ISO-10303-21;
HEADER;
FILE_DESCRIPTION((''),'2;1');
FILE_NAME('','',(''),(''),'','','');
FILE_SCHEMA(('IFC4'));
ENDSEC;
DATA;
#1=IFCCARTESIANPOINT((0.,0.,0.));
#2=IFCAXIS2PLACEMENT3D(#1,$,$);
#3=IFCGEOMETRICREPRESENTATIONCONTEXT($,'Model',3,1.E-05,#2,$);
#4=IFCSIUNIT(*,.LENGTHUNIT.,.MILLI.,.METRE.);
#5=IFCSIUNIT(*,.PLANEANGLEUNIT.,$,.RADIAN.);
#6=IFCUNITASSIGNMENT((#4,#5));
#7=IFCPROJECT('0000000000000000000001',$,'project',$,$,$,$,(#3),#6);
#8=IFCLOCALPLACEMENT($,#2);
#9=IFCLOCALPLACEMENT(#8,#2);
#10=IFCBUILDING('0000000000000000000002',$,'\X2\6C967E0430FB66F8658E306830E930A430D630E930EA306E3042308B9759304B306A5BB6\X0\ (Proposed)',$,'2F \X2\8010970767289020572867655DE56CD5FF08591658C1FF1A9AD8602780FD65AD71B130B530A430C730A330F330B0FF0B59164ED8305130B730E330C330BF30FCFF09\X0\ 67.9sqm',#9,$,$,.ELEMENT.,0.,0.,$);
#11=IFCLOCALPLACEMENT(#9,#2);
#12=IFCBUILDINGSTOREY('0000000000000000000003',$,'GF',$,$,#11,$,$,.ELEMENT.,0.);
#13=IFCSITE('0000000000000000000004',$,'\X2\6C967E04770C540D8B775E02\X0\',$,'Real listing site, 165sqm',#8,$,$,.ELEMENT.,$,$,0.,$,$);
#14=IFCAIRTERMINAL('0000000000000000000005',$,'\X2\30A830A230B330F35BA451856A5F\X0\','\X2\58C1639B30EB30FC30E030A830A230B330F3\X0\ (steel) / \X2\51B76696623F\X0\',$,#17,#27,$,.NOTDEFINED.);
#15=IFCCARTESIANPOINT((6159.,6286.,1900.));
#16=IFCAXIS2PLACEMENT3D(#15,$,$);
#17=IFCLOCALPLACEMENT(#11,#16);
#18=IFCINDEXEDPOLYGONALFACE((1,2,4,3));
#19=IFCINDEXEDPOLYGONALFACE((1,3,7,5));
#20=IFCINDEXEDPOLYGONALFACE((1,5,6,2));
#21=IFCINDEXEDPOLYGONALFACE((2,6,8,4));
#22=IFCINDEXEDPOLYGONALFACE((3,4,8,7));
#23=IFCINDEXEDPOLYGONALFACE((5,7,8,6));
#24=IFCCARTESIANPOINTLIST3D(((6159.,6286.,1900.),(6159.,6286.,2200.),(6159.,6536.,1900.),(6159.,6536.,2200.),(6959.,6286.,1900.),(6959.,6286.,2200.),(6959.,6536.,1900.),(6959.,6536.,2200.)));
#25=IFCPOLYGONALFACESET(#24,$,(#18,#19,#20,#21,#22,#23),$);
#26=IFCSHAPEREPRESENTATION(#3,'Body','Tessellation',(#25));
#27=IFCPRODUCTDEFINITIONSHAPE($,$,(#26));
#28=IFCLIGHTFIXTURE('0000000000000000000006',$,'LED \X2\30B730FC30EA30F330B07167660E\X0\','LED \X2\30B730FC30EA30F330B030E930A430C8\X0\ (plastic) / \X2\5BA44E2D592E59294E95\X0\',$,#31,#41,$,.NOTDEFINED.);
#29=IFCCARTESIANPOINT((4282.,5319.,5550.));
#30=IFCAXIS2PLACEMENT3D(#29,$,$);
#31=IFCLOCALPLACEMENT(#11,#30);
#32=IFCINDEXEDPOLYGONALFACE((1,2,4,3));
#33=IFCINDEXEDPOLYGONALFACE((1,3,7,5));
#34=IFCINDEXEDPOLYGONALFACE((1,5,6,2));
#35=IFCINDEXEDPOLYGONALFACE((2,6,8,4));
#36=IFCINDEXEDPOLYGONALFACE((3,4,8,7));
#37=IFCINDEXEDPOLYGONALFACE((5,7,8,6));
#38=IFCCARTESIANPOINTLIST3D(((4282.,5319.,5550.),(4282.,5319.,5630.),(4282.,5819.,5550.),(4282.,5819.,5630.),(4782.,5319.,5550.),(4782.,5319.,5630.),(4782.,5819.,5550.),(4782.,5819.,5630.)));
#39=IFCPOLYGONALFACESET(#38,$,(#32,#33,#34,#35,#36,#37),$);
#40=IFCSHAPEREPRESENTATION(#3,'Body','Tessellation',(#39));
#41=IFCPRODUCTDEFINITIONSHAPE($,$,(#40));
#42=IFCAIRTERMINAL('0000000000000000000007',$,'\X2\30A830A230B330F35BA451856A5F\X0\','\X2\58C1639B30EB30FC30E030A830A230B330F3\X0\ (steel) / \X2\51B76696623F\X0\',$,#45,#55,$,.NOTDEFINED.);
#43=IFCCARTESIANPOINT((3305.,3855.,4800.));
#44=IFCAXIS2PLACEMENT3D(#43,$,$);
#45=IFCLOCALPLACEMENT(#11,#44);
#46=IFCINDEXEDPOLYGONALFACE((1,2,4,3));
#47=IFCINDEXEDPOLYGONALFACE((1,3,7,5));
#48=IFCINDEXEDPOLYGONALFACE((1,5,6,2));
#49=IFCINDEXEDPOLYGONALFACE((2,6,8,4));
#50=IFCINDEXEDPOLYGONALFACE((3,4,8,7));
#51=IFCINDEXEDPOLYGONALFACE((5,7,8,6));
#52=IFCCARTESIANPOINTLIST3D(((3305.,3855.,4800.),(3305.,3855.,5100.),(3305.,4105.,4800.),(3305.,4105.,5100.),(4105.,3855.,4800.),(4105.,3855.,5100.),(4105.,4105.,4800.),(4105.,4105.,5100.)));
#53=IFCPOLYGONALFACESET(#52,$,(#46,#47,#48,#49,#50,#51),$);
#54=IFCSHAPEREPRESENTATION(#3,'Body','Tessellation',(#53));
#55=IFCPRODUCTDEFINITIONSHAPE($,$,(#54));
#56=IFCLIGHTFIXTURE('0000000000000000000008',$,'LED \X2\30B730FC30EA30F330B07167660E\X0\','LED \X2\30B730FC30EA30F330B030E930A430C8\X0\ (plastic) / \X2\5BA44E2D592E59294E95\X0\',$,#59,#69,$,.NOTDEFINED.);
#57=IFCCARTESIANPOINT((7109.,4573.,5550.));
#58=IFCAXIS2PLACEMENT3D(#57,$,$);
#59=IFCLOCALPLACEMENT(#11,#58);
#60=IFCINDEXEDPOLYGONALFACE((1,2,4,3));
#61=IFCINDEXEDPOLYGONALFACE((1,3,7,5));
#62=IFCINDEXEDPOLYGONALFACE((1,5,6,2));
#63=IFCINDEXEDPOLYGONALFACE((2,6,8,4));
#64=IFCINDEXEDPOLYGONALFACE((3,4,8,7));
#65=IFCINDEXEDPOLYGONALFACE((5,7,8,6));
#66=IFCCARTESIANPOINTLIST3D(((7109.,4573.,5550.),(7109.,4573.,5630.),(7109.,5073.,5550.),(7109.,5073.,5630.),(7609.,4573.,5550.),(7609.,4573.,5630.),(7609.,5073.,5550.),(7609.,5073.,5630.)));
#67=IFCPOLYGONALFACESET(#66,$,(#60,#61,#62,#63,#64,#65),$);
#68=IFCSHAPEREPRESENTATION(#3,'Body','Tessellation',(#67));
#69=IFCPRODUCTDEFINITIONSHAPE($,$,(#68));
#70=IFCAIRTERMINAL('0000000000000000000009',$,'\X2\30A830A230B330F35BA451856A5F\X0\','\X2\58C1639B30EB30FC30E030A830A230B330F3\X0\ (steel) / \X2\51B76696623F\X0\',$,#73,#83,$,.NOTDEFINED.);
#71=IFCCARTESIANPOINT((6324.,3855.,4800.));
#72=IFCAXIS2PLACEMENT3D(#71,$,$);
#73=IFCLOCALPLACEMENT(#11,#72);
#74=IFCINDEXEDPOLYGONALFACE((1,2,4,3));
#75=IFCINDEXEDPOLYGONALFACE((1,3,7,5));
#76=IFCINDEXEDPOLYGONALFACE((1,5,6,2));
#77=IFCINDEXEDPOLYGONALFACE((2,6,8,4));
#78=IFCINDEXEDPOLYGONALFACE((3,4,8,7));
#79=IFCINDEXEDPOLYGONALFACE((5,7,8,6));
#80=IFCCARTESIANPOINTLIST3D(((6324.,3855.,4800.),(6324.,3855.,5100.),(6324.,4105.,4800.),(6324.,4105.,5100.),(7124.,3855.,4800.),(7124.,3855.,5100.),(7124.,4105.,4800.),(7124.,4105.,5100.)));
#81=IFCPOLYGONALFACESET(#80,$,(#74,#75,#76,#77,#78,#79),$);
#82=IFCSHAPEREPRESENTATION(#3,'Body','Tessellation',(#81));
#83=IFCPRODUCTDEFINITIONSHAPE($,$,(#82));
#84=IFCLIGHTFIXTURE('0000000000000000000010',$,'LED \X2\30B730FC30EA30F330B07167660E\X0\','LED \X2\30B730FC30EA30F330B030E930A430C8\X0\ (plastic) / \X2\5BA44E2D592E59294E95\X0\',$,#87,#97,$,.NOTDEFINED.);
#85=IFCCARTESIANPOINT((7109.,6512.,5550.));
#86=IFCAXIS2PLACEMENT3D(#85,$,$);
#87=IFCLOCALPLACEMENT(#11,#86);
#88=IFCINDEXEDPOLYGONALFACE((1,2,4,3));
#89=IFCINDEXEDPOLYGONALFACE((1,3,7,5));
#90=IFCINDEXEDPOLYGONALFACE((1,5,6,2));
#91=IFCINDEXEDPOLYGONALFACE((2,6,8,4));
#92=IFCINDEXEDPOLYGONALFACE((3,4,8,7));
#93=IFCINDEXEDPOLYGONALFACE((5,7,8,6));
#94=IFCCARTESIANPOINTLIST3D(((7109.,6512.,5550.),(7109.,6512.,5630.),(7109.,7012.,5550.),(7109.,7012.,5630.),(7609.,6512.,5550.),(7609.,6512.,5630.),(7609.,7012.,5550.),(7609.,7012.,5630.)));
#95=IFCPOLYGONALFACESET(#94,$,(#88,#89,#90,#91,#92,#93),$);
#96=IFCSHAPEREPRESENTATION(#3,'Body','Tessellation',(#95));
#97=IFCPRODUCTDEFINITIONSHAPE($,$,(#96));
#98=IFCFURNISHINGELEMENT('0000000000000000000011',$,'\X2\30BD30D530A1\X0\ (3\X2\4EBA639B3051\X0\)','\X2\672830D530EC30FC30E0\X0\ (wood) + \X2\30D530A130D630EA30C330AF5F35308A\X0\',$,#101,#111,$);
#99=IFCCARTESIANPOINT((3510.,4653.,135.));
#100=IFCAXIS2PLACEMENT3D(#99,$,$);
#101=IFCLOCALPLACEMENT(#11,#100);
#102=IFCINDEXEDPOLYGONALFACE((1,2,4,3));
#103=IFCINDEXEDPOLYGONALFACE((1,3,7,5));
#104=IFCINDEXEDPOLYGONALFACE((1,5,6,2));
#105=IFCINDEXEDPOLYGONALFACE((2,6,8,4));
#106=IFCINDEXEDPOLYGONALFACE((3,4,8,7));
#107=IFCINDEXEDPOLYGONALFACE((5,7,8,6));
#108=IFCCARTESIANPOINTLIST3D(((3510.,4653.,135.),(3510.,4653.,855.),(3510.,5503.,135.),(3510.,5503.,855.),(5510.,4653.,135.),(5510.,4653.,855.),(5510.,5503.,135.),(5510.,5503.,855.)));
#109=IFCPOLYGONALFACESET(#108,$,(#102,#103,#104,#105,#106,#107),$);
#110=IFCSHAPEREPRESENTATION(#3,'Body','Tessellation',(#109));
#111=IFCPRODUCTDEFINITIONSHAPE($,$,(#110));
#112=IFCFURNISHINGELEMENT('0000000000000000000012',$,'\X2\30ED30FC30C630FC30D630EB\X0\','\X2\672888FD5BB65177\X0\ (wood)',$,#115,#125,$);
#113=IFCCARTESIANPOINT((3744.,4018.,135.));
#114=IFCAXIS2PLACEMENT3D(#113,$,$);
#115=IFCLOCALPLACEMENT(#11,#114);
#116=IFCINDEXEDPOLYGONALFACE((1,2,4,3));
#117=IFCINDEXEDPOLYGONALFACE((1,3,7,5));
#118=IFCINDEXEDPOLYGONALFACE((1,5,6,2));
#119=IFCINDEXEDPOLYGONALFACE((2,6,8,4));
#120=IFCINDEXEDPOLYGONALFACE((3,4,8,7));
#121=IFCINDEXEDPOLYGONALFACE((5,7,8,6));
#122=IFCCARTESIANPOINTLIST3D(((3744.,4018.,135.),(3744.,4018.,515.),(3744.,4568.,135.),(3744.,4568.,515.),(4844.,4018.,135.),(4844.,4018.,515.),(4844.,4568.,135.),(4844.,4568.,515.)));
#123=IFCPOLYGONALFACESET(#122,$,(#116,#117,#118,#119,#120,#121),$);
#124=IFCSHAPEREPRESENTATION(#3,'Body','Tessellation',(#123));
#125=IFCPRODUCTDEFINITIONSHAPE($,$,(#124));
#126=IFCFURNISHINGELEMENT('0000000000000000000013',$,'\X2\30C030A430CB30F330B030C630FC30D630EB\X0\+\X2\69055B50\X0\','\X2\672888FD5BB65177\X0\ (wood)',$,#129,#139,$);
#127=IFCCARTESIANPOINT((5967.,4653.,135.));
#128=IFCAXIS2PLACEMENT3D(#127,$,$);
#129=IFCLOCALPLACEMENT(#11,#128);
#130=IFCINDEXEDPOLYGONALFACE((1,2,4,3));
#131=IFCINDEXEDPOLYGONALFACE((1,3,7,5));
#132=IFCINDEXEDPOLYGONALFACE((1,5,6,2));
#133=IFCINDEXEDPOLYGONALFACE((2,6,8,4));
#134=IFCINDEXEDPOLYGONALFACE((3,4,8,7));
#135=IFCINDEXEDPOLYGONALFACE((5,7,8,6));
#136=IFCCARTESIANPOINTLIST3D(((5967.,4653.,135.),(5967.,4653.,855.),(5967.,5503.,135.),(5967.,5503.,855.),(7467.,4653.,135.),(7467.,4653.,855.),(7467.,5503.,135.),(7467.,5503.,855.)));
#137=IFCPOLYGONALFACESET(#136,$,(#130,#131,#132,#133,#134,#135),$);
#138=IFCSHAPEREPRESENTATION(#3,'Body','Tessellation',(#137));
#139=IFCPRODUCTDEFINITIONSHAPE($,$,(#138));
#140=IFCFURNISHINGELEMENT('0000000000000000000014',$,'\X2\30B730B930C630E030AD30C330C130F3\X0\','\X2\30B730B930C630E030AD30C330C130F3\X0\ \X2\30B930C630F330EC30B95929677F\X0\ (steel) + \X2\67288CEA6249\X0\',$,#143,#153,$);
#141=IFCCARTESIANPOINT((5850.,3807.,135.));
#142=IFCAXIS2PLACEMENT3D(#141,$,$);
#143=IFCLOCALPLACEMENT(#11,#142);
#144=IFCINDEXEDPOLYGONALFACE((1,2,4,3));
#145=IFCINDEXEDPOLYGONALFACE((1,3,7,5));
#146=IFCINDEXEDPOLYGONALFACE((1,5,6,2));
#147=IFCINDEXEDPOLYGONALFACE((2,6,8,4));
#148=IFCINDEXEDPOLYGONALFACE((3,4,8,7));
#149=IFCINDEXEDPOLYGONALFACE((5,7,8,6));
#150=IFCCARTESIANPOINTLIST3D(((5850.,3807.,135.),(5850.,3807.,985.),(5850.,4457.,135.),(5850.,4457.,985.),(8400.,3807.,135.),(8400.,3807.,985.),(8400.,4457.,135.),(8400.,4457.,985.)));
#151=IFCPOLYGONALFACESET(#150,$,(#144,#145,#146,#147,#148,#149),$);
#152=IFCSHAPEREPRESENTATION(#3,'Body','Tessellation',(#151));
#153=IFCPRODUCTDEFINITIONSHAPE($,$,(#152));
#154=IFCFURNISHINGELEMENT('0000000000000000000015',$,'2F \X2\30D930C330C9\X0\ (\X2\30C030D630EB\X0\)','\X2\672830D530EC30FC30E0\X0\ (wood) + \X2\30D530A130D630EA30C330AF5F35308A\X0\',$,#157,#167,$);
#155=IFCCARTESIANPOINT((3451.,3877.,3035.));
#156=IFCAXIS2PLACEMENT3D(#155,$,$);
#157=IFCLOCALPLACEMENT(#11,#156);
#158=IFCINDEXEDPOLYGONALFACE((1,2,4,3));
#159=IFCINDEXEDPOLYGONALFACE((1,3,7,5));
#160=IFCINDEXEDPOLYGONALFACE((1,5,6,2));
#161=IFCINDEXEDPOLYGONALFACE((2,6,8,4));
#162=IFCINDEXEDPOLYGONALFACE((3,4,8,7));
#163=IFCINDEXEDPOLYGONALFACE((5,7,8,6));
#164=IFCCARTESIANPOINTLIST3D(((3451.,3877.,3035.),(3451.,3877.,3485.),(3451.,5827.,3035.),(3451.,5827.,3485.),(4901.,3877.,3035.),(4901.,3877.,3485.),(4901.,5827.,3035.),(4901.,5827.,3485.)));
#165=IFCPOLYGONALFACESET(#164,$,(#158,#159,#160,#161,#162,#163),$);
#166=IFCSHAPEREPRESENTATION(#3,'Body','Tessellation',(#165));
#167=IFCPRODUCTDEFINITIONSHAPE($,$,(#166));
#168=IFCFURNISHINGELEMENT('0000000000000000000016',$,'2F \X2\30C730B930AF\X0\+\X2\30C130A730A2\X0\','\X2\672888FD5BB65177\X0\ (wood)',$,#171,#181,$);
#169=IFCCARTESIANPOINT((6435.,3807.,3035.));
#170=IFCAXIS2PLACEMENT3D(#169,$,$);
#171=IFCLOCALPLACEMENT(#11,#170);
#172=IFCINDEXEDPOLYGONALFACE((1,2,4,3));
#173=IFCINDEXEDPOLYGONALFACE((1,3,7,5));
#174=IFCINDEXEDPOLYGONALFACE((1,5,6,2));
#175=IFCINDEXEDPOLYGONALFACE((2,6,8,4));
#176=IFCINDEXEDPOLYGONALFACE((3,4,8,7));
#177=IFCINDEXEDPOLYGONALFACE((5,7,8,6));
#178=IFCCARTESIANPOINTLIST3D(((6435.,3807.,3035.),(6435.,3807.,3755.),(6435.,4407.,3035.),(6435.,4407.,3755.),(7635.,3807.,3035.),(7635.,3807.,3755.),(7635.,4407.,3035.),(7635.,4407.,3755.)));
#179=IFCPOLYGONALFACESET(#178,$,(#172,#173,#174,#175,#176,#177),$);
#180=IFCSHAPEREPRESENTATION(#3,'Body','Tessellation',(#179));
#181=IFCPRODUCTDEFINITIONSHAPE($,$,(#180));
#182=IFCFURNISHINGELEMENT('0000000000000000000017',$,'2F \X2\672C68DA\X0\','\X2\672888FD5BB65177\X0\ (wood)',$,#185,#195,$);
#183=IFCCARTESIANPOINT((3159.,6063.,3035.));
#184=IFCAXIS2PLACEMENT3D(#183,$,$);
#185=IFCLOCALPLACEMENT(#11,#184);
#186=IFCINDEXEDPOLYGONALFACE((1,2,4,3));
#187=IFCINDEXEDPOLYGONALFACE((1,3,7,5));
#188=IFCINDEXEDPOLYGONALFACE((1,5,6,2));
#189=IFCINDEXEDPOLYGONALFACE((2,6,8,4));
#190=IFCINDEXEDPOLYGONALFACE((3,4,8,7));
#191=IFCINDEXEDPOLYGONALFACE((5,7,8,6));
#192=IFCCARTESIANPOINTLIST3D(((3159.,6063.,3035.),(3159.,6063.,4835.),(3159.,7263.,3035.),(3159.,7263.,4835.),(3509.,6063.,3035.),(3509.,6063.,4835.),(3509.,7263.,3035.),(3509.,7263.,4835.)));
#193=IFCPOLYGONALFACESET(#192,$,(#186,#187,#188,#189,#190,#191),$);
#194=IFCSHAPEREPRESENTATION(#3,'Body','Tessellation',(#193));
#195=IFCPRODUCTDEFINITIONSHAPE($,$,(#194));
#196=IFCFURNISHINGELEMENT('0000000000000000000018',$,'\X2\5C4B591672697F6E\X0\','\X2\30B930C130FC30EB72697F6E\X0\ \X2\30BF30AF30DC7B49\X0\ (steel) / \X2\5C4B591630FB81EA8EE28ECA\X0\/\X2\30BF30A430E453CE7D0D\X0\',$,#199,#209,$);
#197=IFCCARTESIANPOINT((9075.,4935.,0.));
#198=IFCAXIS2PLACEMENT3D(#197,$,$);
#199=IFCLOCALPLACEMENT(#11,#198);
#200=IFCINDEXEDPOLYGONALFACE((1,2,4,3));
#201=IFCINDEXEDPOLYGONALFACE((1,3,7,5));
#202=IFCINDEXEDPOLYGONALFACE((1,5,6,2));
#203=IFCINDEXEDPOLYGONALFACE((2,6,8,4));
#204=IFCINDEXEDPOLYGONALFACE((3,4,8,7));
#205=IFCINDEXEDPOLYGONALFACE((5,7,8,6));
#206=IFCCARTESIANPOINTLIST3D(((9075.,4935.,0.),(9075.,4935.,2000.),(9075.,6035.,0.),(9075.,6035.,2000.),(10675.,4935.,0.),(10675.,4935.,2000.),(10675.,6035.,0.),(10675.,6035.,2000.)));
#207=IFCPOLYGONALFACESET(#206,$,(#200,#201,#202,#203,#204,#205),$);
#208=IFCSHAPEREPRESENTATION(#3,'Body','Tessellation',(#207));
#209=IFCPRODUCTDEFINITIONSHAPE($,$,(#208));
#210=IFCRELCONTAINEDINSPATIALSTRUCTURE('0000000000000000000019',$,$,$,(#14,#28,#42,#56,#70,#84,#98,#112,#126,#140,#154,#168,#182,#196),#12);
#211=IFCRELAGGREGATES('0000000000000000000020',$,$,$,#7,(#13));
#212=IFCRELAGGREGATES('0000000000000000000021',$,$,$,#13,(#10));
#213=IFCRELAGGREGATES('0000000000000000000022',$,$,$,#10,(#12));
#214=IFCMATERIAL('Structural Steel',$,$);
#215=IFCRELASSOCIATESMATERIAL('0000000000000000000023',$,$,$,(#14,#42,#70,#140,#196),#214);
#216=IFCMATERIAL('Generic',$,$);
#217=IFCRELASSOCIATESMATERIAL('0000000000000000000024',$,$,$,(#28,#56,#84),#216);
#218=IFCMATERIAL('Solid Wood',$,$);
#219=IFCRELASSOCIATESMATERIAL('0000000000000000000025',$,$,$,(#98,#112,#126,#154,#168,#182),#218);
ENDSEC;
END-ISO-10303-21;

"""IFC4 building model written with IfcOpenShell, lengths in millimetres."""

from ifc_helpers import new_model, si_unit, frame, frame_2d, origin, place, context, project, spatial, rectangle, extrude, material, element, save


model = new_model("IFC4")

# Units and contexts
model_context = context("Model", 3, precision=1e-05, world=origin())
ifc_project = project(units=[si_unit("LENGTHUNIT", "METRE", prefix="MILLI"), si_unit("PLANEANGLEUNIT", "RADIAN")], contexts=[model_context])

# Site, building, storey
site_placement = place(None, origin())
site = spatial("IfcSite", under=ifc_project, at=site_placement, Name="沖縄県名護市", ObjectType="Real listing site, 165sqm", CompositionType="ELEMENT", RefElevation=0.0)
building_placement = place(site_placement, origin())
building = spatial("IfcBuilding", under=site, at=building_placement, Name="沖縄・書斎とライブラリのある静かな家 (Proposed)", ObjectType="2F 耐震木造在来工法（外壁：高性能断熱サイディング＋外付けシャッター） 67.9sqm", CompositionType="ELEMENT", ElevationOfRefHeight=0.0, ElevationOfTerrain=0.0)
storey_placement = place(building_placement, origin())
storey = spatial("IfcBuildingStorey", under=building, at=storey_placement, Name="GF", CompositionType="ELEMENT", Elevation=0.0)

# Shared definitions
ifc_material_1 = material(Name="Solid Wood")

# Shared definitions
ifc_material_2 = material(Name="Structural Steel")

# Shared definitions
ifc_material_3 = material(Name="Generic")

# Air terminal
air_terminal_1_placement = place(storey_placement, frame((6159.0, 6286.0, 1900.0)))
element("IfcAirTerminal", 1, at=air_terminal_1_placement, inside=storey, material=ifc_material_2, Name="エアコン室内機", Description="壁掛ルームエアコン (steel) / 冷暖房", PredefinedType="NOTDEFINED", context=model_context, shape_type="SweptSolid", body=[
    extrude(rectangle(XDim=800.0, YDim=250.0, at=frame_2d((400.0, 125.0))), frame((6159.0, 6286.0, 1900.0)), (0.0, 0.0, 1.0), 300.0),
])

# Light fixture
light_fixture_1_placement = place(storey_placement, frame((4282.0, 5319.0, 5550.0)))
element("IfcLightFixture", 2, at=light_fixture_1_placement, inside=storey, material=ifc_material_3, Name="LED シーリング照明", Description="LED シーリングライト (plastic) / 室中央天井", PredefinedType="NOTDEFINED", context=model_context, shape_type="SweptSolid", body=[
    extrude(rectangle(XDim=500.0, YDim=500.0, at=frame_2d((250.0, 250.0))), frame((4282.0, 5319.0, 5550.0)), (0.0, 0.0, 1.0), 80.0),
])

# Air terminal
air_terminal_2_placement = place(storey_placement, frame((3305.0, 3855.0, 4800.0)))
element("IfcAirTerminal", 3, at=air_terminal_2_placement, inside=storey, material=ifc_material_2, Name="エアコン室内機", Description="壁掛ルームエアコン (steel) / 冷暖房", PredefinedType="NOTDEFINED", context=model_context, shape_type="SweptSolid", body=[
    extrude(rectangle(XDim=800.0, YDim=250.0, at=frame_2d((400.0, 125.0))), frame((3305.0, 3855.0, 4800.0)), (0.0, 0.0, 1.0), 300.0),
])

# Light fixture
light_fixture_2_placement = place(storey_placement, frame((7109.0, 4573.0, 5550.0)))
element("IfcLightFixture", 4, at=light_fixture_2_placement, inside=storey, material=ifc_material_3, Name="LED シーリング照明", Description="LED シーリングライト (plastic) / 室中央天井", PredefinedType="NOTDEFINED", context=model_context, shape_type="SweptSolid", body=[
    extrude(rectangle(XDim=500.0, YDim=500.0, at=frame_2d((250.0, 250.0))), frame((7109.0, 4573.0, 5550.0)), (0.0, 0.0, 1.0), 80.0),
])

# Air terminal
air_terminal_3_placement = place(storey_placement, frame((6324.0, 3855.0, 4800.0)))
element("IfcAirTerminal", 5, at=air_terminal_3_placement, inside=storey, material=ifc_material_2, Name="エアコン室内機", Description="壁掛ルームエアコン (steel) / 冷暖房", PredefinedType="NOTDEFINED", context=model_context, shape_type="SweptSolid", body=[
    extrude(rectangle(XDim=800.0, YDim=250.0, at=frame_2d((400.0, 125.0))), frame((6324.0, 3855.0, 4800.0)), (0.0, 0.0, 1.0), 300.0),
])

# Light fixture
light_fixture_3_placement = place(storey_placement, frame((7109.0, 6512.0, 5550.0)))
element("IfcLightFixture", 6, at=light_fixture_3_placement, inside=storey, material=ifc_material_3, Name="LED シーリング照明", Description="LED シーリングライト (plastic) / 室中央天井", PredefinedType="NOTDEFINED", context=model_context, shape_type="SweptSolid", body=[
    extrude(rectangle(XDim=500.0, YDim=500.0, at=frame_2d((250.0, 250.0))), frame((7109.0, 6512.0, 5550.0)), (0.0, 0.0, 1.0), 80.0),
])

# Furnishing elements
furnishing_1_placement = place(storey_placement, frame((3510.0, 4653.0, 135.0)))
element("IfcFurnishingElement", 7, at=furnishing_1_placement, inside=storey, material=ifc_material_1, Name="ソファ (3人掛け)", Description="木フレーム (wood) + ファブリック張り", context=model_context, shape_type="SweptSolid", body=[
    extrude(rectangle(XDim=2000.0, YDim=850.0, at=frame_2d((1000.0, 425.0))), frame((3510.0, 4653.0, 135.0)), (0.0, 0.0, 1.0), 720.0),
])
furnishing_2_placement = place(storey_placement, frame((3744.0, 4018.0, 135.0)))
element("IfcFurnishingElement", 8, at=furnishing_2_placement, inside=storey, material=ifc_material_1, Name="ローテーブル", Description="木製家具 (wood)", context=model_context, shape_type="SweptSolid", body=[
    extrude(rectangle(XDim=1100.0, YDim=550.0, at=frame_2d((550.0, 275.0))), frame((3744.0, 4018.0, 135.0)), (0.0, 0.0, 1.0), 380.0),
])
furnishing_3_placement = place(storey_placement, frame((5967.0, 4653.0, 135.0)))
element("IfcFurnishingElement", 9, at=furnishing_3_placement, inside=storey, material=ifc_material_1, Name="ダイニングテーブル+椅子", Description="木製家具 (wood)", context=model_context, shape_type="SweptSolid", body=[
    extrude(rectangle(XDim=1500.0, YDim=850.0, at=frame_2d((750.0, 425.0))), frame((5967.0, 4653.0, 135.0)), (0.0, 0.0, 1.0), 720.0),
])
furnishing_4_placement = place(storey_placement, frame((5850.0, 3807.0, 135.0)))
element("IfcFurnishingElement", 10, at=furnishing_4_placement, inside=storey, material=ifc_material_2, Name="システムキッチン", Description="システムキッチン ステンレス天板 (steel) + 木質扉", context=model_context, shape_type="SweptSolid", body=[
    extrude(rectangle(XDim=2550.0, YDim=650.0, at=frame_2d((1275.0, 325.0))), frame((5850.0, 3807.0, 135.0)), (0.0, 0.0, 1.0), 850.0),
])
furnishing_5_placement = place(storey_placement, frame((3451.0, 3877.0, 3035.0)))
element("IfcFurnishingElement", 11, at=furnishing_5_placement, inside=storey, material=ifc_material_1, Name="2F ベッド (ダブル)", Description="木フレーム (wood) + ファブリック張り", context=model_context, shape_type="SweptSolid", body=[
    extrude(rectangle(XDim=1450.0, YDim=1950.0, at=frame_2d((725.0, 975.0))), frame((3451.0, 3877.0, 3035.0)), (0.0, 0.0, 1.0), 450.0),
])
furnishing_6_placement = place(storey_placement, frame((6435.0, 3807.0, 3035.0)))
element("IfcFurnishingElement", 12, at=furnishing_6_placement, inside=storey, material=ifc_material_1, Name="2F デスク+チェア", Description="木製家具 (wood)", context=model_context, shape_type="SweptSolid", body=[
    extrude(rectangle(XDim=1200.0, YDim=600.0, at=frame_2d((600.0, 300.0))), frame((6435.0, 3807.0, 3035.0)), (0.0, 0.0, 1.0), 720.0),
])
furnishing_7_placement = place(storey_placement, frame((3159.0, 6063.0, 3035.0)))
element("IfcFurnishingElement", 13, at=furnishing_7_placement, inside=storey, material=ifc_material_1, Name="2F 本棚", Description="木製家具 (wood)", context=model_context, shape_type="SweptSolid", body=[
    extrude(rectangle(XDim=350.0, YDim=1200.0, at=frame_2d((175.0, 600.0))), frame((3159.0, 6063.0, 3035.0)), (0.0, 0.0, 1.0), 1800.0),
])
furnishing_8_placement = place(storey_placement, frame((9075.0, 4935.0, 0.0)))
element("IfcFurnishingElement", 14, at=furnishing_8_placement, inside=storey, material=ifc_material_2, Name="屋外物置", Description="スチール物置 タクボ等 (steel) / 屋外・自転車/タイヤ収納", context=model_context, shape_type="SweptSolid", body=[
    extrude(rectangle(XDim=1600.0, YDim=1100.0, at=frame_2d((800.0, 550.0))), frame((9075.0, 4935.0, 0.0)), (0.0, 0.0, 1.0), 2000.0),
])

save(model, "model.ifc")
